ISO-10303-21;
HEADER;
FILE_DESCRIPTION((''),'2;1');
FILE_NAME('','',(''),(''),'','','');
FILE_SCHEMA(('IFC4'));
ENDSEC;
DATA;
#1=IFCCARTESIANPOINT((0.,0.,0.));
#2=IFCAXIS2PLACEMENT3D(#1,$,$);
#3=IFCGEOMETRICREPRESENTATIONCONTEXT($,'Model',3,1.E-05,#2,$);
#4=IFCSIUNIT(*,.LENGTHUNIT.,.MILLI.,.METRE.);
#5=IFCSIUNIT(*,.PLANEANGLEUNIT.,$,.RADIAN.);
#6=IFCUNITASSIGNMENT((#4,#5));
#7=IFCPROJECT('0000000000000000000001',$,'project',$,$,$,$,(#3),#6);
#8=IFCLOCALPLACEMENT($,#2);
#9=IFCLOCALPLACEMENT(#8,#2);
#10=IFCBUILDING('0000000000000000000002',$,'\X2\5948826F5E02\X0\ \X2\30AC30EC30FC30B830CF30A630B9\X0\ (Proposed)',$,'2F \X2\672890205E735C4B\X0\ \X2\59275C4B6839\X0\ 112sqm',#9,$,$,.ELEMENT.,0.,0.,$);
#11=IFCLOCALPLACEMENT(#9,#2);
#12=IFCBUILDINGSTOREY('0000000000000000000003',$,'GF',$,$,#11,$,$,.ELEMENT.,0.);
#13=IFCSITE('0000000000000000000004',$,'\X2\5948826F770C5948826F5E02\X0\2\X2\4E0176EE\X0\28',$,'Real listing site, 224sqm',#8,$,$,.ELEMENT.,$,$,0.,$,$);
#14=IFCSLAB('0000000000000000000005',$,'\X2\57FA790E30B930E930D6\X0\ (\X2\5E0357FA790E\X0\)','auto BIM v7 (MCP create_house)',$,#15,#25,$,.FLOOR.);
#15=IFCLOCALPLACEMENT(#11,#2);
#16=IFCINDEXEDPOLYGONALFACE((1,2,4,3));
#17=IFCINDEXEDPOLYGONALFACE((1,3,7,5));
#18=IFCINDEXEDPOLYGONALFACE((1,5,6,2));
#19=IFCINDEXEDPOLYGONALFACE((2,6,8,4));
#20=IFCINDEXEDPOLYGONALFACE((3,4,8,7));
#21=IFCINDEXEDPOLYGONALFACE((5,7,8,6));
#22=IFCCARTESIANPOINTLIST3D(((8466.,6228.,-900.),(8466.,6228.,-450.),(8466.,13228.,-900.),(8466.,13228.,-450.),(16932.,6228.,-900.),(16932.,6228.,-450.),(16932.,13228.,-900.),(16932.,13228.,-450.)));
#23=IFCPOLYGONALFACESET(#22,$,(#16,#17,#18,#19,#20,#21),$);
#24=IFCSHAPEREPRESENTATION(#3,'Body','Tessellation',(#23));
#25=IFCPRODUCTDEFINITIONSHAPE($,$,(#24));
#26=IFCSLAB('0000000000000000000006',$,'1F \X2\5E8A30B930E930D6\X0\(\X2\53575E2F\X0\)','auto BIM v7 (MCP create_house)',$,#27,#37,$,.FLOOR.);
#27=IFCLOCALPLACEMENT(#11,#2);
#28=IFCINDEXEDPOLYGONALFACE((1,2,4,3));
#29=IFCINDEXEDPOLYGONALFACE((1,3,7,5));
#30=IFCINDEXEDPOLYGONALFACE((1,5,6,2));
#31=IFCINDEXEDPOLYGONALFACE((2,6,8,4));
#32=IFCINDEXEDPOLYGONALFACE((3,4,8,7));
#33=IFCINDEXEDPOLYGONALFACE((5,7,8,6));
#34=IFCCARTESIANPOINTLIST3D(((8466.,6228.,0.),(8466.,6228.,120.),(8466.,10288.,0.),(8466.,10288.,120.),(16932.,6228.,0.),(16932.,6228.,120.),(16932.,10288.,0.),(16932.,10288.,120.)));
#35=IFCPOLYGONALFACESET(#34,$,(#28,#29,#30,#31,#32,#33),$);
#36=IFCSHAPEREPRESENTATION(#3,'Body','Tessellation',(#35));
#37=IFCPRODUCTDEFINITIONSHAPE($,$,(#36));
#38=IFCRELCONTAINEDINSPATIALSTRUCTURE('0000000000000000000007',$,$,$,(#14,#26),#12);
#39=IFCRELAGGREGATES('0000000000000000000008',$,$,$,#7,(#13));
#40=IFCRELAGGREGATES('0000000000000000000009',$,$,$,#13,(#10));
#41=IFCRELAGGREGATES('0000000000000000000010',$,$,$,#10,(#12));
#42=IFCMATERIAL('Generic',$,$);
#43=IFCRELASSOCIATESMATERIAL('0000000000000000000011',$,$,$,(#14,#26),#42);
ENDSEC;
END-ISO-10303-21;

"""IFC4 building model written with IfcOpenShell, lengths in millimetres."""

from ifc_helpers import new_model, si_unit, frame, frame_2d, origin, place, context, project, spatial, rectangle, extrude, material, element, save


model = new_model("IFC4")

# Units and contexts
model_context = context("Model", 3, precision=1e-05, world=origin())
ifc_project = project(units=[si_unit("LENGTHUNIT", "METRE", prefix="MILLI"), si_unit("PLANEANGLEUNIT", "RADIAN")], contexts=[model_context])

# Site, building, storey
site_placement = place(None, origin())
site = spatial("IfcSite", under=ifc_project, at=site_placement, Name="奈良県奈良市2丁目28", ObjectType="Real listing site, 224sqm", CompositionType="ELEMENT", RefElevation=0.0)
building_placement = place(site_placement, origin())
building = spatial("IfcBuilding", under=site, at=building_placement, Name="奈良市 ガレージハウス (Proposed)", ObjectType="2F 木造平屋 大屋根 112sqm", CompositionType="ELEMENT", ElevationOfRefHeight=0.0, ElevationOfTerrain=0.0)
storey_placement = place(building_placement, origin())
storey = spatial("IfcBuildingStorey", under=building, at=storey_placement, Name="GF", CompositionType="ELEMENT", Elevation=0.0)

# Slabs
ifc_material = material(Name="Generic")
slab_1_placement = place(storey_placement, frame((4233.0, 3114.0, -450.0)))
element("IfcSlab", 1, at=slab_1_placement, inside=storey, material=ifc_material, Name="基礎スラブ (布基礎)", Description="auto BIM v7 (MCP create_house)", PredefinedType="FLOOR", context=model_context, shape_type="SweptSolid", body=[
    extrude(rectangle(XDim=8466.0, YDim=7000.0, at=frame_2d((4233.0, 3500.0))), frame((4233.0, 3114.0, -450.0)), (0.0, 0.0, 1.0), 450.0),
])
slab_2_placement = place(storey_placement, frame((4233.0, 3114.0, 0.0)))
element("IfcSlab", 2, at=slab_2_placement, inside=storey, material=ifc_material, Name="1F 床スラブ(南帯)", Description="auto BIM v7 (MCP create_house)", PredefinedType="FLOOR", context=model_context, shape_type="SweptSolid", body=[
    extrude(rectangle(XDim=8466.0, YDim=4060.0, at=frame_2d((4233.0, 2030.0))), frame((4233.0, 3114.0, 0.0)), (0.0, 0.0, 1.0), 120.0),
])

save(model, "model.ifc")
